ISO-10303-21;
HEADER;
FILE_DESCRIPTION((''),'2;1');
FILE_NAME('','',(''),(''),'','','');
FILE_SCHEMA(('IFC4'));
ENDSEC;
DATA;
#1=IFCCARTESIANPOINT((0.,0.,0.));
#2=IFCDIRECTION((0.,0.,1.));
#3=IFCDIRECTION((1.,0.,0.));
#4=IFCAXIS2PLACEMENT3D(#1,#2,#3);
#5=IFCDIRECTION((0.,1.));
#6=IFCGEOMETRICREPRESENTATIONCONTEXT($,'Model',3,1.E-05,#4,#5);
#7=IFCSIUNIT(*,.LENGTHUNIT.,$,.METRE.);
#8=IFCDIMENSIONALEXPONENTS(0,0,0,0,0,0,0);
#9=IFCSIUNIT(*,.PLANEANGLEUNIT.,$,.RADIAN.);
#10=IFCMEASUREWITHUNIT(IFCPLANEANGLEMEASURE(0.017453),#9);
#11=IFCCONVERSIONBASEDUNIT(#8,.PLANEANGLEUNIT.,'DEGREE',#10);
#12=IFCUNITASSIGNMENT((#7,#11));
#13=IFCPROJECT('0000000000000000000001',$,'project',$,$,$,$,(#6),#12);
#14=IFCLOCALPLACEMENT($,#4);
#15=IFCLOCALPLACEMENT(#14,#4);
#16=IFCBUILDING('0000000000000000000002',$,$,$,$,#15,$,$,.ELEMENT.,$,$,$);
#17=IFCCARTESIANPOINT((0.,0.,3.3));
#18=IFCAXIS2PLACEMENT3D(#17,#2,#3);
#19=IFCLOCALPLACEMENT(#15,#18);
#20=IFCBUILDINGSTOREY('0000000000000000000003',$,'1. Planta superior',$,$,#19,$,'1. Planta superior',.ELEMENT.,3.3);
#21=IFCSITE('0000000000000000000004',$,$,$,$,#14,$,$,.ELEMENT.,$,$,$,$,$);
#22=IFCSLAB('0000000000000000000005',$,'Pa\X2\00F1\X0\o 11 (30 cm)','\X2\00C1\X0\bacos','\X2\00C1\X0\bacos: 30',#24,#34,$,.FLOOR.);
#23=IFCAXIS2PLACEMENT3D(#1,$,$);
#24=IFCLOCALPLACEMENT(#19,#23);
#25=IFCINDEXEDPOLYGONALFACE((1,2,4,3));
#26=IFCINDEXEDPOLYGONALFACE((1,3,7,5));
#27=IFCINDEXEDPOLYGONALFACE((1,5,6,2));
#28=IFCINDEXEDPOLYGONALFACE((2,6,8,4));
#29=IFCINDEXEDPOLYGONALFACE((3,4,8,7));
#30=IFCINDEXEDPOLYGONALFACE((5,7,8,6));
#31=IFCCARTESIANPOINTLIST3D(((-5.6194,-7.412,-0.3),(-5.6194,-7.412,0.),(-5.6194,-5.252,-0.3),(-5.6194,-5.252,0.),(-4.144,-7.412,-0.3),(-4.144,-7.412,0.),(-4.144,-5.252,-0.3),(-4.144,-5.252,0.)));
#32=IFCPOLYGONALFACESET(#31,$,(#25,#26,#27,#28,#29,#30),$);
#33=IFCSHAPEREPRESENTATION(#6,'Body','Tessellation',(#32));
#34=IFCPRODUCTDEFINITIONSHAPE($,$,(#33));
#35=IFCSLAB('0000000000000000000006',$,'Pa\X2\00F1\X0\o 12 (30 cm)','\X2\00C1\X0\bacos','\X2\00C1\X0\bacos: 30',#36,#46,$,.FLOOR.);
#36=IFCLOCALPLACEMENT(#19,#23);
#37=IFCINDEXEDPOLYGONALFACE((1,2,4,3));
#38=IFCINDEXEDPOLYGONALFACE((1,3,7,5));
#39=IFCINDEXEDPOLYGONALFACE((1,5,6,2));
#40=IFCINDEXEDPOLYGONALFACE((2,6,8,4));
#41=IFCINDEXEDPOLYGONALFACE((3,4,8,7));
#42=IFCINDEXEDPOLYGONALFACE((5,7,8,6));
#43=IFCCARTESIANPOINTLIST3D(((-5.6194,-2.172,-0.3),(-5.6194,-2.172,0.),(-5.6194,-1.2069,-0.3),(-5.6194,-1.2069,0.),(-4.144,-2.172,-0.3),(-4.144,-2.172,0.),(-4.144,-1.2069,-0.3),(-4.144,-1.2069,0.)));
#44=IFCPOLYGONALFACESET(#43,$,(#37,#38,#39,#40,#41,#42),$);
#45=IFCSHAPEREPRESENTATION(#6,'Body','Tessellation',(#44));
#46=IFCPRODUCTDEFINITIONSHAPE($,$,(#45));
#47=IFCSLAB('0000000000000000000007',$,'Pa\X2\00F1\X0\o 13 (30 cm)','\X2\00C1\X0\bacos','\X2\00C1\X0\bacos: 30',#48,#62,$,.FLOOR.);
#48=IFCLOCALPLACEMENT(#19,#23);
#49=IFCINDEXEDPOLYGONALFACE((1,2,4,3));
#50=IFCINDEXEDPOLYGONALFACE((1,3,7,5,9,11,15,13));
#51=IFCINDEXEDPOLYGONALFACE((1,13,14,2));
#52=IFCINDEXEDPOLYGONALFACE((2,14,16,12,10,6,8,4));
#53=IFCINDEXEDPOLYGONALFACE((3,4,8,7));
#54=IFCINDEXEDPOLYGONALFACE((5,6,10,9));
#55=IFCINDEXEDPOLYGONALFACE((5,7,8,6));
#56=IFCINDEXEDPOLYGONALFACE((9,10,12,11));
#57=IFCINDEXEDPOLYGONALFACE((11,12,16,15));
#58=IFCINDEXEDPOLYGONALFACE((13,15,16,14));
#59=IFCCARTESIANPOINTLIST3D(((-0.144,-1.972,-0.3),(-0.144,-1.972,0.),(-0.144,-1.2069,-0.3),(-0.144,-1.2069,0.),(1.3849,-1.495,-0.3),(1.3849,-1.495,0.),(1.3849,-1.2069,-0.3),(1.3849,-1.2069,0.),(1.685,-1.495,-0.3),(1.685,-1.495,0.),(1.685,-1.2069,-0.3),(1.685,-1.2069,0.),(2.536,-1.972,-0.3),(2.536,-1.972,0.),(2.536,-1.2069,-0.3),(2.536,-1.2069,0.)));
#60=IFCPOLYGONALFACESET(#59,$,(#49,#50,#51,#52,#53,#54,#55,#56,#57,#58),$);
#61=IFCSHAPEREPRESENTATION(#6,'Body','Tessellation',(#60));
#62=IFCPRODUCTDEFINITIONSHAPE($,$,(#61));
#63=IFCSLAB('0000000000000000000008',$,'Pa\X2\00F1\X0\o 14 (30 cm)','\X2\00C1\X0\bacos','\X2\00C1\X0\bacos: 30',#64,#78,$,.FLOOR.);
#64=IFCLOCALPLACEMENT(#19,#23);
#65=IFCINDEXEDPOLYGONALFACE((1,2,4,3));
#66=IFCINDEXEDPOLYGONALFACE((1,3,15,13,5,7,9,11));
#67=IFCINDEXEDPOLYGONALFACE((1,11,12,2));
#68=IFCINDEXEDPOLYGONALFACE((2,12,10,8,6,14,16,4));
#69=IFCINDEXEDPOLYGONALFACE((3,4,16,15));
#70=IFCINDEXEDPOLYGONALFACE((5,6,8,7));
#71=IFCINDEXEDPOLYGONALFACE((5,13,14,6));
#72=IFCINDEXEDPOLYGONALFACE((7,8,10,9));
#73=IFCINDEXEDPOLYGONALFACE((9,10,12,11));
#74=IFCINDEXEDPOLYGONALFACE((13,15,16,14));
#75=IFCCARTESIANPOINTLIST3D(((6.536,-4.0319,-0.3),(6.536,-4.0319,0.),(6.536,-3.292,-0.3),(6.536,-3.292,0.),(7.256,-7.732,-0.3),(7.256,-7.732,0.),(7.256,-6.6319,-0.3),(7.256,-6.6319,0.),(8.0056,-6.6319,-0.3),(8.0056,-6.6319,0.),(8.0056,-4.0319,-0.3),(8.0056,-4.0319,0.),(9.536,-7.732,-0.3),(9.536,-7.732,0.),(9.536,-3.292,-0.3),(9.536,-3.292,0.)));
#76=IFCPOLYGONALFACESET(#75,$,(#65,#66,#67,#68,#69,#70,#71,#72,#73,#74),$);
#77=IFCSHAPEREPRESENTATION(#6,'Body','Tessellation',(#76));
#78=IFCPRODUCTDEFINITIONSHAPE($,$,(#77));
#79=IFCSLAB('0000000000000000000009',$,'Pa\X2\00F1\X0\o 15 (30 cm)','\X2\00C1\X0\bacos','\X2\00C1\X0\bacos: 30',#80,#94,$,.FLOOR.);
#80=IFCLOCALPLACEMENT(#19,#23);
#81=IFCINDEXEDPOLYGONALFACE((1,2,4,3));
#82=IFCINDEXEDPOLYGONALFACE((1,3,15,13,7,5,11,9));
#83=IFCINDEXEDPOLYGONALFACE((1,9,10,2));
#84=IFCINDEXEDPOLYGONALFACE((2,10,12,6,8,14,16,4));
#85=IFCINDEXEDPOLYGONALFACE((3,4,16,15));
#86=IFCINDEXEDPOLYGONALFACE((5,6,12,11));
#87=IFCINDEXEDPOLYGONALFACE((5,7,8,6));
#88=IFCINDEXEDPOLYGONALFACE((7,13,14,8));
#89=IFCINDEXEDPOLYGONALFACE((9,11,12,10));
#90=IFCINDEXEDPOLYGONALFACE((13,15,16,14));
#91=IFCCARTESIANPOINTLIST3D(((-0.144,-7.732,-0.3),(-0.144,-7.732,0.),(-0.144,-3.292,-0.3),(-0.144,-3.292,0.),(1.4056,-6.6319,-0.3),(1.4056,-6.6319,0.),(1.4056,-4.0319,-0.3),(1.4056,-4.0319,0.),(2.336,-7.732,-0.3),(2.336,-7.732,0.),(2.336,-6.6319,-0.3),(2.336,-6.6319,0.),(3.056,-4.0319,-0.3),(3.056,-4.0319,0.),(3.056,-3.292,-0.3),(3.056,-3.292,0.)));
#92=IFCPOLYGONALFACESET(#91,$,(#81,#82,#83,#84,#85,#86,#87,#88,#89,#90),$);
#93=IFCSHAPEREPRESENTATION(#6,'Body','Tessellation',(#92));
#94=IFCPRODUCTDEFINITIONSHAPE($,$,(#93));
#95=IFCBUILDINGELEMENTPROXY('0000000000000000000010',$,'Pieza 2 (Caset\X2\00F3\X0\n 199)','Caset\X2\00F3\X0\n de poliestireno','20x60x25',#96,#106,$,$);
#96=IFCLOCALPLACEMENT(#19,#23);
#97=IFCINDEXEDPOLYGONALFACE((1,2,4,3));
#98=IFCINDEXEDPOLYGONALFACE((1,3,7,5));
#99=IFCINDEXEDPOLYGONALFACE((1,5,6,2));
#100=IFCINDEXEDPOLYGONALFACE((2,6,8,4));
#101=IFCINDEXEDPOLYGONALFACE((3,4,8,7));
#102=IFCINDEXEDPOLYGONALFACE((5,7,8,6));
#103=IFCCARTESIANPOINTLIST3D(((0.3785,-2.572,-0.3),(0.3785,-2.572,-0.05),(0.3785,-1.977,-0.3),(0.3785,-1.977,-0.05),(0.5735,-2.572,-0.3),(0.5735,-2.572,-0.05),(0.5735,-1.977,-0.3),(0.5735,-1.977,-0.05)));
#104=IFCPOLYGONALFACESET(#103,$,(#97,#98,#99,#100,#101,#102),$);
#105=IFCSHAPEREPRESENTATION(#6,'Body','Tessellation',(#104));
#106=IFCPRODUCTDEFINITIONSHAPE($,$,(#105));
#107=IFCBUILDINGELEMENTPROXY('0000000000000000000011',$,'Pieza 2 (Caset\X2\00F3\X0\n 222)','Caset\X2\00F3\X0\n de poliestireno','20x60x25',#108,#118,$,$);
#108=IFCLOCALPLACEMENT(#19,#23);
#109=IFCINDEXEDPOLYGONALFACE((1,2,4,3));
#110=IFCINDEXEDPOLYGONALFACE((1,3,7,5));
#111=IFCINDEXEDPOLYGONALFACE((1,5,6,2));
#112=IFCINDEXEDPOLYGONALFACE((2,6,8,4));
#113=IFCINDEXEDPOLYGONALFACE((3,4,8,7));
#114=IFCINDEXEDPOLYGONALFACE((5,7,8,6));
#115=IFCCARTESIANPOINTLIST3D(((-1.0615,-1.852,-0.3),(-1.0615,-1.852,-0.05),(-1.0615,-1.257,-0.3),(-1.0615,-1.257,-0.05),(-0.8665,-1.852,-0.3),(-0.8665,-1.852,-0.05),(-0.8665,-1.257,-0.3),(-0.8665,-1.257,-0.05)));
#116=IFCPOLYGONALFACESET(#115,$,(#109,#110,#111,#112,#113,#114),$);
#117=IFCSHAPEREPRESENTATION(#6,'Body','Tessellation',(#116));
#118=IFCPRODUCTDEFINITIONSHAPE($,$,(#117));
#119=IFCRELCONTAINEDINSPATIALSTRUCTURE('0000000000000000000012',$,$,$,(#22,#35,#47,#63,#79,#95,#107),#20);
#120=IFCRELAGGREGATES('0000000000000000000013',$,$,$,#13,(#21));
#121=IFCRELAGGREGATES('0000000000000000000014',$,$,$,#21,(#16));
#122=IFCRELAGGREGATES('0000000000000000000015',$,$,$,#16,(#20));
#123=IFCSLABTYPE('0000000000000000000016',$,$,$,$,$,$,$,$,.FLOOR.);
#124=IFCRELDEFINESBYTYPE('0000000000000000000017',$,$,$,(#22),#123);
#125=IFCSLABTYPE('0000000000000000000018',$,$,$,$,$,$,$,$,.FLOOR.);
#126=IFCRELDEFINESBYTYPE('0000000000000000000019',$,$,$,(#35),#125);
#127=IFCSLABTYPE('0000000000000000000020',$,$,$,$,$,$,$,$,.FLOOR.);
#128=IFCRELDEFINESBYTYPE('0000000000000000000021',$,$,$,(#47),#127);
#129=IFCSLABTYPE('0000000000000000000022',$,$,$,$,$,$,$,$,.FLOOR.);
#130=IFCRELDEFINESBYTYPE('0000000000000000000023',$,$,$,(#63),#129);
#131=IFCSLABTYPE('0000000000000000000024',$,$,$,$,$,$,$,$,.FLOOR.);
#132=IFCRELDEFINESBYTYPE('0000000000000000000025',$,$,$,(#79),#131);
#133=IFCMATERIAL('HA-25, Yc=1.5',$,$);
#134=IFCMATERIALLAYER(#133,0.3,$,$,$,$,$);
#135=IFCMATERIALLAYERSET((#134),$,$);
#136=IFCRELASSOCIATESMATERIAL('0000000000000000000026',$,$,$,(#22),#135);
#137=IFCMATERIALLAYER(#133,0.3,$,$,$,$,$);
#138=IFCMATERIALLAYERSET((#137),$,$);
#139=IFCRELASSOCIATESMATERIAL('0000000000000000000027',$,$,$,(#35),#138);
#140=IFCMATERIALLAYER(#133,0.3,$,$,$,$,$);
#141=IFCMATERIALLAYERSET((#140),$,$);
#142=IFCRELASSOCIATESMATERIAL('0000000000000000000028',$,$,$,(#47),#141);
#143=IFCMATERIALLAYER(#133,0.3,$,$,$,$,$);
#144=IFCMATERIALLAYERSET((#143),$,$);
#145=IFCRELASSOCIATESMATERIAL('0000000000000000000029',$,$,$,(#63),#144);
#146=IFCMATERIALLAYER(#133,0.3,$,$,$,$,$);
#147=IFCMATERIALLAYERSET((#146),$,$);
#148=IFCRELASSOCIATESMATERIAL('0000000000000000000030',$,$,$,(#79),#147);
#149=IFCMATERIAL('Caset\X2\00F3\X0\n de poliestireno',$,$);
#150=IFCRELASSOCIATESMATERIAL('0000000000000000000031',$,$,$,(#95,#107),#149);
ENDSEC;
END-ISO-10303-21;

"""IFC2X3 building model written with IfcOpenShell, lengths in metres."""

from ifc_helpers import new_model, entity, si_unit, converted_unit, direction, frame, origin_with_axes, origin_2d_with_axis, place, context, project, spatial, polyline, rectangle, outline, extrude, source, transform, mapped, material, layer, layer_set, layer_usage, type_object, element, save


model = new_model("IFC2X3")

# Units and contexts
model_context = context("Model", 3, precision=1e-05, world=origin_with_axes(), true_north=direction((0.0, 1.0)))
ifc_project = project(units=[si_unit("LENGTHUNIT", "METRE"), converted_unit("PLANEANGLEUNIT", "DEGREE", entity("IfcPlaneAngleMeasure", 0.017453), si_unit("PLANEANGLEUNIT", "RADIAN"), dimensions=[0, 0, 0, 0, 0, 0, 0])], contexts=[model_context])

# Site, building, storey
site_placement = place(None, origin_with_axes())
site = spatial("IfcSite", under=ifc_project, at=site_placement, CompositionType="ELEMENT")
building_placement = place(site_placement, origin_with_axes())
building = spatial("IfcBuilding", under=site, at=building_placement, CompositionType="ELEMENT")
storey_placement = place(building_placement, frame((0.0, 0.0, 3.3), z_axis=(0.0, 0.0, 1.0), x_axis=(1.0, 0.0, 0.0)))
storey = spatial("IfcBuildingStorey", under=building, at=storey_placement, Name="1. Planta superior", LongName="1. Planta superior", CompositionType="ELEMENT", Elevation=3.3)

# Shared definitions
ifc_material_1 = material(Name="HA-25, Yc=1.5")

# Slabs
ifc_layer_1 = layer(ifc_material_1, 0.3)
ifc_layer_set_1 = layer_set([ifc_layer_1])
ifc_layer_usage_1 = layer_usage(ifc_layer_set_1, "AXIS3", "POSITIVE", 0.0)
slab_type_1 = type_object("IfcSlabType", PredefinedType="FLOOR")
slab_1_placement = place(storey_placement, frame((0.0, 0.0, -0.3), z_axis=(0.0, 0.0, 1.0), x_axis=(1.0, 0.0, 0.0)))
element("IfcSlab", 1, at=slab_1_placement, inside=storey, type_object=slab_type_1, material=ifc_layer_usage_1, Name="Paño 11 (30 cm)", Description="Ábacos", ObjectType="Ábacos: 30", PredefinedType="FLOOR", context=model_context, shape_type="SweptSolid", body=[
    extrude(outline(polyline([(-4.144, -5.252), (-5.6194, -5.252), (-5.6194, -7.412), (-4.144, -7.412), (-4.144, -5.252)])), origin_with_axes(), (0.0, 0.0, 1.0), 0.3),
])
ifc_layer_2 = layer(ifc_material_1, 0.3)
ifc_layer_set_2 = layer_set([ifc_layer_2])
ifc_layer_usage_2 = layer_usage(ifc_layer_set_2, "AXIS3", "POSITIVE", 0.0)
slab_type_2 = type_object("IfcSlabType", PredefinedType="FLOOR")
slab_2_placement = place(storey_placement, frame((0.0, 0.0, -0.3), z_axis=(0.0, 0.0, 1.0), x_axis=(1.0, 0.0, 0.0)))
element("IfcSlab", 2, at=slab_2_placement, inside=storey, type_object=slab_type_2, material=ifc_layer_usage_2, Name="Paño 12 (30 cm)", Description="Ábacos", ObjectType="Ábacos: 30", PredefinedType="FLOOR", context=model_context, shape_type="SweptSolid", body=[
    extrude(outline(polyline([(-5.6194, -1.2069), (-5.6194, -2.172), (-4.144, -2.172), (-4.144, -1.2069), (-5.6194, -1.2069)])), origin_with_axes(), (0.0, 0.0, 1.0), 0.3),
])
ifc_layer_3 = layer(ifc_material_1, 0.3)
ifc_layer_set_3 = layer_set([ifc_layer_3])
ifc_layer_usage_3 = layer_usage(ifc_layer_set_3, "AXIS3", "POSITIVE", 0.0)
slab_type_3 = type_object("IfcSlabType", PredefinedType="FLOOR")
slab_3_placement = place(storey_placement, frame((0.0, 0.0, -0.3), z_axis=(0.0, 0.0, 1.0), x_axis=(1.0, 0.0, 0.0)))
element("IfcSlab", 3, at=slab_3_placement, inside=storey, type_object=slab_type_3, material=ifc_layer_usage_3, Name="Paño 13 (30 cm)", Description="Ábacos", ObjectType="Ábacos: 30", PredefinedType="FLOOR", context=model_context, shape_type="SweptSolid", body=[
    extrude(outline(polyline([(2.536, -1.2069), (1.685, -1.2069), (1.685, -1.495), (1.3849, -1.495), (1.3849, -1.2069), (-0.144, -1.2069), (-0.144, -1.972), (2.536, -1.972), (2.536, -1.2069)])), origin_with_axes(), (0.0, 0.0, 1.0), 0.3),
])
ifc_layer_4 = layer(ifc_material_1, 0.3)
ifc_layer_set_4 = layer_set([ifc_layer_4])
ifc_layer_usage_4 = layer_usage(ifc_layer_set_4, "AXIS3", "POSITIVE", 0.0)
slab_type_4 = type_object("IfcSlabType", PredefinedType="FLOOR")
slab_4_placement = place(storey_placement, frame((0.0, 0.0, -0.3), z_axis=(0.0, 0.0, 1.0), x_axis=(1.0, 0.0, 0.0)))
element("IfcSlab", 4, at=slab_4_placement, inside=storey, type_object=slab_type_4, material=ifc_layer_usage_4, Name="Paño 14 (30 cm)", Description="Ábacos", ObjectType="Ábacos: 30", PredefinedType="FLOOR", context=model_context, shape_type="SweptSolid", body=[
    extrude(outline(polyline([(9.536, -3.292), (6.536, -3.292), (6.536, -4.0319), (8.0056, -4.0319), (8.0056, -6.6319), (7.256, -6.6319), (7.256, -7.732), (9.536, -7.732), (9.536, -3.292)])), origin_with_axes(), (0.0, 0.0, 1.0), 0.3),
])
ifc_layer_5 = layer(ifc_material_1, 0.3)
ifc_layer_set_5 = layer_set([ifc_layer_5])
ifc_layer_usage_5 = layer_usage(ifc_layer_set_5, "AXIS3", "POSITIVE", 0.0)
slab_type_5 = type_object("IfcSlabType", PredefinedType="FLOOR")
slab_5_placement = place(storey_placement, frame((0.0, 0.0, -0.3), z_axis=(0.0, 0.0, 1.0), x_axis=(1.0, 0.0, 0.0)))
element("IfcSlab", 5, at=slab_5_placement, inside=storey, type_object=slab_type_5, material=ifc_layer_usage_5, Name="Paño 15 (30 cm)", Description="Ábacos", ObjectType="Ábacos: 30", PredefinedType="FLOOR", context=model_context, shape_type="SweptSolid", body=[
    extrude(outline(polyline([(1.4056, -6.6319), (1.4056, -4.0319), (3.056, -4.0319), (3.056, -3.292), (-0.144, -3.292), (-0.144, -7.732), (2.336, -7.732), (2.336, -6.6319), (1.4056, -6.6319)])), origin_with_axes(), (0.0, 0.0, 1.0), 0.3),
])

# Building element proxies
ifc_material_2 = material(Name="Casetón de poliestireno")
shared_shape = source(origin_with_axes(), model_context, "Body", "SweptSolid", [
    extrude(rectangle(XDim=0.195, YDim=0.25, at=origin_2d_with_axis()), origin_with_axes(), (0.0, 0.0, 1.0), 0.595),
])
placement_1 = place(storey_placement, frame((0.476, -2.572, -0.175), z_axis=(0.0, 1.0, 0.0), x_axis=(-1.0, 0.0, 0.0)))
for number, where, z_axis, x_axis, name in (
    (6, (0.0, 0.0, 0.0), (0.0, 0.0, 1.0), (1.0, 0.0, 0.0), "Pieza 2 (Casetón 199)"),
):
    element("IfcBuildingElementProxy", number, at=place(placement_1, frame(where, z_axis=z_axis, x_axis=x_axis)), inside=storey, material=ifc_material_2, Name=name, Description="Casetón de poliestireno", ObjectType="20x60x25", context=model_context, shape_type="MappedRepresentation", body=[
        mapped(shared_shape, transform((0.0, 0.0, 0.0), x_axis=(1.0, 0.0, 0.0), y_axis=(0.0, 1.0, 0.0), z_axis=(0.0, 0.0, 1.0))),
    ])
placement_2 = place(storey_placement, frame((-0.964, -1.852, -0.175), z_axis=(0.0, 1.0, 0.0), x_axis=(-1.0, 0.0, 0.0)))
for number, where, z_axis, x_axis, name in (
    (7, (0.0, 0.0, 0.0), (0.0, 0.0, 1.0), (1.0, 0.0, 0.0), "Pieza 2 (Casetón 222)"),
):
    element("IfcBuildingElementProxy", number, at=place(placement_2, frame(where, z_axis=z_axis, x_axis=x_axis)), inside=storey, material=ifc_material_2, Name=name, Description="Casetón de poliestireno", ObjectType="20x60x25", context=model_context, shape_type="MappedRepresentation", body=[
        mapped(shared_shape, transform((0.0, 0.0, 0.0), x_axis=(1.0, 0.0, 0.0), y_axis=(0.0, 1.0, 0.0), z_axis=(0.0, 0.0, 1.0))),
    ])

save(model, "model.ifc")
